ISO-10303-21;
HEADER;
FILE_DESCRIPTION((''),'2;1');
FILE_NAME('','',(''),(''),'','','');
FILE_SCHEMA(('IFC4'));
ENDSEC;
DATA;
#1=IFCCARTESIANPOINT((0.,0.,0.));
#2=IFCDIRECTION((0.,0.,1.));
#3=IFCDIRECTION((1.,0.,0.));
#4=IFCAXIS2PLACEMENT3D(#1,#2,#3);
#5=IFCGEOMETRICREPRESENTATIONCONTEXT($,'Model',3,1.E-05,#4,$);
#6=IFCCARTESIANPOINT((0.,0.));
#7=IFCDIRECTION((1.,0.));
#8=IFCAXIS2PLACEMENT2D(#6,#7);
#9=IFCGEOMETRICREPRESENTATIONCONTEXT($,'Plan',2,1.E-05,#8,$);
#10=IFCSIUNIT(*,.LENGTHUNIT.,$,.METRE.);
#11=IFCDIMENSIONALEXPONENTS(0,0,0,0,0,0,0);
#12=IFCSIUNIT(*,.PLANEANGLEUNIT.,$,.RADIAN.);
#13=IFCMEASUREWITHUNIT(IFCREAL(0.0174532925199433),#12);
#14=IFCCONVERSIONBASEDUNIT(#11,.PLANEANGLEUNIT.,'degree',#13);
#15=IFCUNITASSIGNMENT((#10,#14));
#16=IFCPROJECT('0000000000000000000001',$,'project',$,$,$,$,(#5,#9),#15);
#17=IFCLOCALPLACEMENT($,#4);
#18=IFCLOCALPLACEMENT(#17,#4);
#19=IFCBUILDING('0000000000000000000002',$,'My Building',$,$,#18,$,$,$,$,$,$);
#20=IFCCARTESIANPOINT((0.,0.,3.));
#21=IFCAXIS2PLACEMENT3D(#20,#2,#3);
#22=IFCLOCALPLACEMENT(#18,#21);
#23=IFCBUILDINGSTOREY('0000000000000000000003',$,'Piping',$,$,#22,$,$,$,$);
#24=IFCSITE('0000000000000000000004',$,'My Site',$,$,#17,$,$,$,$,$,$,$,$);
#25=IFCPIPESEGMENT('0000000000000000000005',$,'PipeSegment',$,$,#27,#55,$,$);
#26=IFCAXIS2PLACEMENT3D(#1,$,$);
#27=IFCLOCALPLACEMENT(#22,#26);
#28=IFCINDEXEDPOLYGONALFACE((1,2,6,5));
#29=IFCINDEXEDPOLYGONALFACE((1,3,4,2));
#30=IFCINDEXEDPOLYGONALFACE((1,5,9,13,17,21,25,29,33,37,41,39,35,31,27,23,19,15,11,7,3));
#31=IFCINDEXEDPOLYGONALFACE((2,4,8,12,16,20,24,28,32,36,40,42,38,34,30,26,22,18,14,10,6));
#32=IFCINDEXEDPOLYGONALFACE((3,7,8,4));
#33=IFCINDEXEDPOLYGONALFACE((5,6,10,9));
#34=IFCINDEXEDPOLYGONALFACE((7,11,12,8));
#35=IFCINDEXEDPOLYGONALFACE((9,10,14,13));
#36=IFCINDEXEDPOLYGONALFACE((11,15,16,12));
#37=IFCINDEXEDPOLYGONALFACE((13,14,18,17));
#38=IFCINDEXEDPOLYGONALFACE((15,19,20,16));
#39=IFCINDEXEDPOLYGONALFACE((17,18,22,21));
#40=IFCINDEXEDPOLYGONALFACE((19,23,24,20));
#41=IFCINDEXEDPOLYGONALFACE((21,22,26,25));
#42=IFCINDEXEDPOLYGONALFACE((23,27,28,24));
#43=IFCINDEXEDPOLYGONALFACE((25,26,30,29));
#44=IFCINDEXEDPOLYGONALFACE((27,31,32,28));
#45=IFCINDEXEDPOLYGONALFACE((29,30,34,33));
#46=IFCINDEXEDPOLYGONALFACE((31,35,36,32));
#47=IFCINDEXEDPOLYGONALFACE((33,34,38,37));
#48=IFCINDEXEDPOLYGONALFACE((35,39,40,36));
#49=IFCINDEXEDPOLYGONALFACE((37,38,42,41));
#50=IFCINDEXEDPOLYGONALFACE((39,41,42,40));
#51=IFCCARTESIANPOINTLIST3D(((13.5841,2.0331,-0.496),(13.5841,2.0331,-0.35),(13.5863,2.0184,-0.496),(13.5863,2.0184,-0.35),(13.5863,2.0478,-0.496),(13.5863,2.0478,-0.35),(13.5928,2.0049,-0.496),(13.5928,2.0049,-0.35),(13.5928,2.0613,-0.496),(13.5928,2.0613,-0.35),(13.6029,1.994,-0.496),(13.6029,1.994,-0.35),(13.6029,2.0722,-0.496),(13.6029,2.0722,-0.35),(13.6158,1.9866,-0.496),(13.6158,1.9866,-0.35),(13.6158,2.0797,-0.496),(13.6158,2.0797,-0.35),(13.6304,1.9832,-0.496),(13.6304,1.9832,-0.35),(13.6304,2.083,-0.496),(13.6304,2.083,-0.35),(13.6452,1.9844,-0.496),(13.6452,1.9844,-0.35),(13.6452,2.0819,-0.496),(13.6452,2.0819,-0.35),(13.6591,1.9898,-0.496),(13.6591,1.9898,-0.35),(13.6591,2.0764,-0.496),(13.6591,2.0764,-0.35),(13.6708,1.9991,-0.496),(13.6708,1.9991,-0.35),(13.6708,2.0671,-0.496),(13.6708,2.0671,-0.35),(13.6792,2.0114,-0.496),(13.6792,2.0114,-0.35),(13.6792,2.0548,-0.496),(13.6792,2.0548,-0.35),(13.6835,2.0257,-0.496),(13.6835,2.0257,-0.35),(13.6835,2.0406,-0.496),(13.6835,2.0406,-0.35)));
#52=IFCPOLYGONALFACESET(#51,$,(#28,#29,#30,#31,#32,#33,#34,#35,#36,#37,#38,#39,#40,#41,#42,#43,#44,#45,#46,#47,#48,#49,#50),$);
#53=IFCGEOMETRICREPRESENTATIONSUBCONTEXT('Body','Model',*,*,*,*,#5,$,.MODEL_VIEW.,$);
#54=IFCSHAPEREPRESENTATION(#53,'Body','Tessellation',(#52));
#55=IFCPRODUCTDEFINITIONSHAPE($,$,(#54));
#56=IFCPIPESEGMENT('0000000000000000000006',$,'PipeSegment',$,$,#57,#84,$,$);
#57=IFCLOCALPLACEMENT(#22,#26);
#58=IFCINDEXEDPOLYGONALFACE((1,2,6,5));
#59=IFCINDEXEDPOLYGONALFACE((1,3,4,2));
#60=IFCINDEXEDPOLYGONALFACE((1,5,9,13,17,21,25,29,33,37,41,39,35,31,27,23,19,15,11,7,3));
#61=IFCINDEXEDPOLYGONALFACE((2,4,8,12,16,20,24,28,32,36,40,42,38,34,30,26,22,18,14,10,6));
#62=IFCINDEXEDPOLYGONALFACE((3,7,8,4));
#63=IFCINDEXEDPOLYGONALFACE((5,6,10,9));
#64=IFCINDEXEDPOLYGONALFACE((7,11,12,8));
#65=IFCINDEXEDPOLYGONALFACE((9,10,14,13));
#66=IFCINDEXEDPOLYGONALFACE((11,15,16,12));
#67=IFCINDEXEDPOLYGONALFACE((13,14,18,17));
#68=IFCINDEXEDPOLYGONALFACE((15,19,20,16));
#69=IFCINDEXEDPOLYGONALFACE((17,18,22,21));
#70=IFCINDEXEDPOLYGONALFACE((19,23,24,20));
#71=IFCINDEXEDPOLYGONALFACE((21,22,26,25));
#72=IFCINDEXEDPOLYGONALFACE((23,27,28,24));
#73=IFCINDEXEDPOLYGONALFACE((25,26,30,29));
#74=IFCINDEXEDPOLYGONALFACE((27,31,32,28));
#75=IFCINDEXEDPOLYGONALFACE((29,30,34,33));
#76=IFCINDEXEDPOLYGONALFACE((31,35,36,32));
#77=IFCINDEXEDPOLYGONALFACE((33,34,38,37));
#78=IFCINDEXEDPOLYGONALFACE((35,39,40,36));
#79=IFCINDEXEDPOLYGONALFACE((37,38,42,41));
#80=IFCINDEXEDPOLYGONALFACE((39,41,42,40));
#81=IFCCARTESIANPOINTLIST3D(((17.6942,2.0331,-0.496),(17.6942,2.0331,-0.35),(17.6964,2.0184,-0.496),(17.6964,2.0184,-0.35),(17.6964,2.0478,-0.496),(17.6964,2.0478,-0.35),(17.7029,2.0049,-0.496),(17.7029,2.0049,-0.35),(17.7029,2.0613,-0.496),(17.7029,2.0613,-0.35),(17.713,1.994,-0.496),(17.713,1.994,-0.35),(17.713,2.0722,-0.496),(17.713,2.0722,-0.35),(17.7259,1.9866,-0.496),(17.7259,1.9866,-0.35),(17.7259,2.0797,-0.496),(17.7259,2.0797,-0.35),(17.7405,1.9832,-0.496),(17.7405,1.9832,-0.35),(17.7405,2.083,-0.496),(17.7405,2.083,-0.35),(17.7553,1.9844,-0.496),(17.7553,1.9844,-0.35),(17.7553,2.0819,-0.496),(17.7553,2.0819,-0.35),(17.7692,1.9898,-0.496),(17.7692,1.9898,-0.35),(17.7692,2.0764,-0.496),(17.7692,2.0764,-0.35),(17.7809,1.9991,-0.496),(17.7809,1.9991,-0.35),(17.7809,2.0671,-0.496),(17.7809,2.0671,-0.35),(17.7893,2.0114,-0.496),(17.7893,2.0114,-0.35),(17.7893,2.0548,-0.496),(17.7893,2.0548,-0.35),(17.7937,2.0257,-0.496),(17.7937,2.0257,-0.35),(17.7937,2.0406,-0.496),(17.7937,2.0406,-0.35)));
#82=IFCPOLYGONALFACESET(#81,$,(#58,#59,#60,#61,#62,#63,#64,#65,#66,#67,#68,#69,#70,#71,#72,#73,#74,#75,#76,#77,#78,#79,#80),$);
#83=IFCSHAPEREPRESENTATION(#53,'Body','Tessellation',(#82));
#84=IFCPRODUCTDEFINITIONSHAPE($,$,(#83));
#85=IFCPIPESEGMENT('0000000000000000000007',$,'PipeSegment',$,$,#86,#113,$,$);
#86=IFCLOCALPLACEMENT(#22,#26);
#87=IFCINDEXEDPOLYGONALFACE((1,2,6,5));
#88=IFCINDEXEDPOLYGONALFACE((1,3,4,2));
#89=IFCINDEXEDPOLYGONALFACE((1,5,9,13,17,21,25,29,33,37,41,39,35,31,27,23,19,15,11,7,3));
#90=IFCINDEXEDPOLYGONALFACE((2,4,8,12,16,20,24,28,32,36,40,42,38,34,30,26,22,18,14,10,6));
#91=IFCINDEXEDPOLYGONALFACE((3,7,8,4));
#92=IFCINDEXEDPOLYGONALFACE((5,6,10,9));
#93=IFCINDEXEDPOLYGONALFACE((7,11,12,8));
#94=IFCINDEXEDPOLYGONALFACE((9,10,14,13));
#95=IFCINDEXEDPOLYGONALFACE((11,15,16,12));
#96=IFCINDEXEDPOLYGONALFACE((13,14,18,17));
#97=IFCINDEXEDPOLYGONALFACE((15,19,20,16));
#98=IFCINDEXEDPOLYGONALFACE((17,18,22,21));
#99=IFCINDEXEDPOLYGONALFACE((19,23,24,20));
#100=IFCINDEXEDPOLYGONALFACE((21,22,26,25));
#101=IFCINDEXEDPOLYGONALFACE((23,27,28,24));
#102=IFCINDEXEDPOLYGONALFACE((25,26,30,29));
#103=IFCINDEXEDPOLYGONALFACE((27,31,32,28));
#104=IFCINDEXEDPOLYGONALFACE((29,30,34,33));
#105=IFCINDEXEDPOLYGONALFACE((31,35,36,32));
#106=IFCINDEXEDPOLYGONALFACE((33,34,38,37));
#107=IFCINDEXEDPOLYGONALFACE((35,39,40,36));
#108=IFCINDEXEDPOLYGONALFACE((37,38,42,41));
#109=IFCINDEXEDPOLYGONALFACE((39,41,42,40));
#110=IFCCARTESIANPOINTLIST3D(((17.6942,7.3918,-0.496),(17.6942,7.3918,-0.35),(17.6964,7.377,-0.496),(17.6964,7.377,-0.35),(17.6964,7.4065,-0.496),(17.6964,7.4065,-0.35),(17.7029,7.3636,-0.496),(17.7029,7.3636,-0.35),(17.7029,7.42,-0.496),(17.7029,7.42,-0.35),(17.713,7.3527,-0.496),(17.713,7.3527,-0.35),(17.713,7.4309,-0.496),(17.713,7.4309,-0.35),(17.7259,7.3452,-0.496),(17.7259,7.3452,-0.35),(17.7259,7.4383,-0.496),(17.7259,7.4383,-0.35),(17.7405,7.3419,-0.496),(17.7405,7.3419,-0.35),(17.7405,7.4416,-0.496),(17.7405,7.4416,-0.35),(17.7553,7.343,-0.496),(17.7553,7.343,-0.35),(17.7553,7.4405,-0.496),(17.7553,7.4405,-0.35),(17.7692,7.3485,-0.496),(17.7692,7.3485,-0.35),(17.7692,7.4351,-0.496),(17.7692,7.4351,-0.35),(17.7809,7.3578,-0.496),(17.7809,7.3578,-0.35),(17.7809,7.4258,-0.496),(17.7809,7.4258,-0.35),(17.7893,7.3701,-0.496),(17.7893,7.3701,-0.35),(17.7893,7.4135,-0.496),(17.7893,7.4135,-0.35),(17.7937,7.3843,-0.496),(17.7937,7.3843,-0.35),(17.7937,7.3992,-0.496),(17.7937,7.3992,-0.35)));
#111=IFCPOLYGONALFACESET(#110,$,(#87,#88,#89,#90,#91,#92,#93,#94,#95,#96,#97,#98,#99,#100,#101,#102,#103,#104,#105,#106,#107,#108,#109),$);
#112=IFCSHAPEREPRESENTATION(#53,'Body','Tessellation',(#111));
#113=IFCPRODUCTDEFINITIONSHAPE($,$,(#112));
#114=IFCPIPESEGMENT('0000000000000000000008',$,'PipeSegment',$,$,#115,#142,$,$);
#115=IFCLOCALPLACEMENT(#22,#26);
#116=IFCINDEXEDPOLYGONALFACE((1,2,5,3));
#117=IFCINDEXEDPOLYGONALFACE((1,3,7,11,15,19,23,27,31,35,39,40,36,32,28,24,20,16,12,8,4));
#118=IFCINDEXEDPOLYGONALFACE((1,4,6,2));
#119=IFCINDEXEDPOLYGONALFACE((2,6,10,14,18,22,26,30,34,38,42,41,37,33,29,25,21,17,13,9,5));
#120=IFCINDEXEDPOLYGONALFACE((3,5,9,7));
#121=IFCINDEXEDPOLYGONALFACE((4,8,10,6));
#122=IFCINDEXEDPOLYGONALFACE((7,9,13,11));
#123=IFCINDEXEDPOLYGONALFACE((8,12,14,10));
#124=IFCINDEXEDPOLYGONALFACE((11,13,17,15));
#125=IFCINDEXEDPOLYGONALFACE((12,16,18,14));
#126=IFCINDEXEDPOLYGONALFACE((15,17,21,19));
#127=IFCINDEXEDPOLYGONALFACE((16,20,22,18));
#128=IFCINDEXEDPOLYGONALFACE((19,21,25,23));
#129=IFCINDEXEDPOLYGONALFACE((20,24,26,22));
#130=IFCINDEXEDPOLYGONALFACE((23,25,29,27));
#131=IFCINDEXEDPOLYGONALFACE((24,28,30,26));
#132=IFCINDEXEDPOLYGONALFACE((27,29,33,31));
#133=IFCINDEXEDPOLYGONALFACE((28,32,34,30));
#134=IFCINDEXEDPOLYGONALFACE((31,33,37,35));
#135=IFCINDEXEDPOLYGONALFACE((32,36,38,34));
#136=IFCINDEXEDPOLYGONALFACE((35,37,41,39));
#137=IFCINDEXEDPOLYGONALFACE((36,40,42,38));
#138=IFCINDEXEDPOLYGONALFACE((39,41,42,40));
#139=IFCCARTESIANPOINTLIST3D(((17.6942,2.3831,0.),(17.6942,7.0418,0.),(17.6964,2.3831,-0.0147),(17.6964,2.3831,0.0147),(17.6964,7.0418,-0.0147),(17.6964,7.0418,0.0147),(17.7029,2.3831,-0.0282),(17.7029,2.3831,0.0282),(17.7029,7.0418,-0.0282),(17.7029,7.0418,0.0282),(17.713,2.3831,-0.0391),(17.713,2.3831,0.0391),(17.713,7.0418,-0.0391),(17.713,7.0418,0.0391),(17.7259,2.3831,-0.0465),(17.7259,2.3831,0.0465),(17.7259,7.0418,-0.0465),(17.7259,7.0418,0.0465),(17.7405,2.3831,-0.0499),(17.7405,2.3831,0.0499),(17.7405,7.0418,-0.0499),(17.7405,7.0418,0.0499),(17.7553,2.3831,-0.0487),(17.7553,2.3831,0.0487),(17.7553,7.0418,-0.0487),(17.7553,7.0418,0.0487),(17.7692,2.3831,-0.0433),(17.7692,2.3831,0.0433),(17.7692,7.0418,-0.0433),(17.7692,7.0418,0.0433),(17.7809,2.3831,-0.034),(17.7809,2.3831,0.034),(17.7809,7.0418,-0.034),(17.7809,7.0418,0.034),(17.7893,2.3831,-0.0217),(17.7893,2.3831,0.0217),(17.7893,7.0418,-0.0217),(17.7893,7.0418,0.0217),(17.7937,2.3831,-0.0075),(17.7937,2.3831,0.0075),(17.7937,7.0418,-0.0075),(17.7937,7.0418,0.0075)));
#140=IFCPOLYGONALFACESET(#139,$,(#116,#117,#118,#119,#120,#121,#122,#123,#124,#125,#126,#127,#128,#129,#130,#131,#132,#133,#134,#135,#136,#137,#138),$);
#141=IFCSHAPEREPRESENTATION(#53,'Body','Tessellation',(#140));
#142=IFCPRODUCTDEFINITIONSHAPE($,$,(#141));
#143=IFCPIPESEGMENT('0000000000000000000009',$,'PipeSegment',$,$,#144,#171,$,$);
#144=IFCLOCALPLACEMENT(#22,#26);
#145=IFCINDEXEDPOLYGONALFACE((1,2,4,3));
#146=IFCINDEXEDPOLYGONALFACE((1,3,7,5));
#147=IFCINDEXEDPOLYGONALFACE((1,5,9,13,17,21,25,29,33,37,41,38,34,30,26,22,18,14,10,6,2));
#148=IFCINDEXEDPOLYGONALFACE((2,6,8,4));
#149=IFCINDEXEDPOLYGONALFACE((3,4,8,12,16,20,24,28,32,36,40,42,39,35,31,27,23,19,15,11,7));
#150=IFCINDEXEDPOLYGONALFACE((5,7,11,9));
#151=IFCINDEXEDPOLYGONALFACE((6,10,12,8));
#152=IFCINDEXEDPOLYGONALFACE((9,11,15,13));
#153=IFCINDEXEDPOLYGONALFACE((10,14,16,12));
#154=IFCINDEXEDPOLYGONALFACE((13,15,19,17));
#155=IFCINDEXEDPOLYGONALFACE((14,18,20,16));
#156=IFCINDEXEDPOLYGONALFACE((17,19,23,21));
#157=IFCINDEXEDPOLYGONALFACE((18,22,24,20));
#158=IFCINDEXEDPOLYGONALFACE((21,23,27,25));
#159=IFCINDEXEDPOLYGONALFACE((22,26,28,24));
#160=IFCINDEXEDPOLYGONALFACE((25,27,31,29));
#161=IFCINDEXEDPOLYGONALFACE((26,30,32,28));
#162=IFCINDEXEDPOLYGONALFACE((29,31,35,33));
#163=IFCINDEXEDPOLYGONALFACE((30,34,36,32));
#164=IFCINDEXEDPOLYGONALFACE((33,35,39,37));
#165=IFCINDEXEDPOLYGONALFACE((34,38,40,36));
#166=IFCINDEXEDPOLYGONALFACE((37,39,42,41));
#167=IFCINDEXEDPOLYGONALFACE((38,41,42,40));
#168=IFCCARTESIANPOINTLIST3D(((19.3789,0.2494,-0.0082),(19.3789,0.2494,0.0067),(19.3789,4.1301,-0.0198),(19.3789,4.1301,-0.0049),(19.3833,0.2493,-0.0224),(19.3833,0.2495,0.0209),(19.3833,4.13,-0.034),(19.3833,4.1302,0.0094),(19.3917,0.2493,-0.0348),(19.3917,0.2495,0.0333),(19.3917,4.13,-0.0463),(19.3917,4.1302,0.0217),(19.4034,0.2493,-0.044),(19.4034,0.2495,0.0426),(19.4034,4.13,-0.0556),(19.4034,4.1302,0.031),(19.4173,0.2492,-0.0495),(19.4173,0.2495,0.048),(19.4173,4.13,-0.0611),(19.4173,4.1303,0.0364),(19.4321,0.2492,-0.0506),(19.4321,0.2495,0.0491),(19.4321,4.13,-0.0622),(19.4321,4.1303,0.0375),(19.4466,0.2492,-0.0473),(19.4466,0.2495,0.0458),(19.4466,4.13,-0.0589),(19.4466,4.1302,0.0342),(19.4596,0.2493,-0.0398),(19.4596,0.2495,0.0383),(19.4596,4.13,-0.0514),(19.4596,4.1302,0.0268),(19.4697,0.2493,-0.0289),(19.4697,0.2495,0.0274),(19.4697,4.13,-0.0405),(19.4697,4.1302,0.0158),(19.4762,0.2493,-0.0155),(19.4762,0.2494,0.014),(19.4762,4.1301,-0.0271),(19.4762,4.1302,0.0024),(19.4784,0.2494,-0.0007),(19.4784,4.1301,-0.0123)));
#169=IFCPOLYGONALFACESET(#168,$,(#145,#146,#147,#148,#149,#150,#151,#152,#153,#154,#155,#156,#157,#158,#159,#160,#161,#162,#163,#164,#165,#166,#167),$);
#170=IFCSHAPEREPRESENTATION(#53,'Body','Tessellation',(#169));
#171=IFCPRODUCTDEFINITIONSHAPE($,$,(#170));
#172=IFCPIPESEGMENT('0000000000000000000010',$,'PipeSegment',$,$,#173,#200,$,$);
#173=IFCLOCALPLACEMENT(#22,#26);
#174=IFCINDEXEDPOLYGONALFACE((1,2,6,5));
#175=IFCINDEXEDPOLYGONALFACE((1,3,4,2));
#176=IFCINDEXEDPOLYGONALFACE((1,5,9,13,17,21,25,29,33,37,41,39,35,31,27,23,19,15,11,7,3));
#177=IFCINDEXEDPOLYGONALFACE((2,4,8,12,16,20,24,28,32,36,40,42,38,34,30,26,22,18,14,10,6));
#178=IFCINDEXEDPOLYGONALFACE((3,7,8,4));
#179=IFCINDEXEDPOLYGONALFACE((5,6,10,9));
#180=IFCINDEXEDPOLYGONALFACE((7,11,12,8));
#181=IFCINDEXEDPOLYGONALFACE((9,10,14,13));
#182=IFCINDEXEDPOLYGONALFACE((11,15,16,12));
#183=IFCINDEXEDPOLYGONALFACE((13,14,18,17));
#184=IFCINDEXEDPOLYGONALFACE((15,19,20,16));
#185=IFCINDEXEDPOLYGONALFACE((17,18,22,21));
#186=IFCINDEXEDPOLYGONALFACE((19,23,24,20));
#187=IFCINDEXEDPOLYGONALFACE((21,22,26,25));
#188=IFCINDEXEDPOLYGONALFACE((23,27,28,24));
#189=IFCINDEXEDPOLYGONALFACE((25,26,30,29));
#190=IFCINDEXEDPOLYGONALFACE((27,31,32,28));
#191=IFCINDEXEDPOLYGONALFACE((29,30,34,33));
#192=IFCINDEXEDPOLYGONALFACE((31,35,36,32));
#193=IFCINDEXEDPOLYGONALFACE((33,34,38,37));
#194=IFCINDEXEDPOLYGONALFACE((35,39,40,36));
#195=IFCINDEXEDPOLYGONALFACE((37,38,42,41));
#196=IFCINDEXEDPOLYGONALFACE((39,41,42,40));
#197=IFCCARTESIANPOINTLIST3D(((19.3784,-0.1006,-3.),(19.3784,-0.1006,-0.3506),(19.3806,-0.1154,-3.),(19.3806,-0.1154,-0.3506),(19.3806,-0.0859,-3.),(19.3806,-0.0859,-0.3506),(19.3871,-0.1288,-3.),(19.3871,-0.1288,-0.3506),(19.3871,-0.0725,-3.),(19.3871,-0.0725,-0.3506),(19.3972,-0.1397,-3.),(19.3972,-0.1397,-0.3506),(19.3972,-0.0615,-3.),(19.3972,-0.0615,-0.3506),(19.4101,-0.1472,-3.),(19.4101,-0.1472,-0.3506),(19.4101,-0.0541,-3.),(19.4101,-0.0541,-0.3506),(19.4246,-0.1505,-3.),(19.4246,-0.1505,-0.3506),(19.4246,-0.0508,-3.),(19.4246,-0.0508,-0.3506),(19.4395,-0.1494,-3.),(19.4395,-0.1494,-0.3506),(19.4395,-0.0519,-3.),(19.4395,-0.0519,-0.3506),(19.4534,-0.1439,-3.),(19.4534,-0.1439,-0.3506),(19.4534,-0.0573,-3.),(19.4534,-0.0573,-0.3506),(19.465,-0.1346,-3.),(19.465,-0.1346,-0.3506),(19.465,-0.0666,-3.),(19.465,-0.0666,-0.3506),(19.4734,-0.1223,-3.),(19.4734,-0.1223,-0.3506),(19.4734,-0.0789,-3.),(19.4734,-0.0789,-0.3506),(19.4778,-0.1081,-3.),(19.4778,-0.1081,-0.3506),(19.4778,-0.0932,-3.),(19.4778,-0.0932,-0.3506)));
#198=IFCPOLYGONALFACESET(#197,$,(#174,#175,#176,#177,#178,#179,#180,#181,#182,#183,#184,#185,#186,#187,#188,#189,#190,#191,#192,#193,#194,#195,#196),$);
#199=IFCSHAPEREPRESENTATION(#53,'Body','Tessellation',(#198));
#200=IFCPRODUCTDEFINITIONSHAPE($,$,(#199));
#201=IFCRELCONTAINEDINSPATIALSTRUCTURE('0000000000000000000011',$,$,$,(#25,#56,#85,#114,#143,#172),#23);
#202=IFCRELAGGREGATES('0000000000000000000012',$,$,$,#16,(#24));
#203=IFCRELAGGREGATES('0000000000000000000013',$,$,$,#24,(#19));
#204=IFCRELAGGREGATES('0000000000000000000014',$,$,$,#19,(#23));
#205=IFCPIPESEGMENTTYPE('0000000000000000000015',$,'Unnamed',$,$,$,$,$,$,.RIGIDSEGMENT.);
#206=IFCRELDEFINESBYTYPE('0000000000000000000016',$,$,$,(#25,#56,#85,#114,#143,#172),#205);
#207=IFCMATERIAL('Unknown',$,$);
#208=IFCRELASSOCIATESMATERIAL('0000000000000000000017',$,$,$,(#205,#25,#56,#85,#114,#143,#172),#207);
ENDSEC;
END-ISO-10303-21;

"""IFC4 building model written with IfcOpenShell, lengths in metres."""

from ifc_helpers import new_model, entity, si_unit, converted_unit, frame, origin_with_axes, origin_2d_with_axis, place, context, subcontext, project, spatial, circle, extrude, material, material_profile, profile_set, profile_usage, type_object, element, save


model = new_model("IFC4")

# Units and contexts
model_context = context("Model", 3, precision=1e-05, world=origin_with_axes())
plan_context = context("Plan", 2, precision=1e-05, world=origin_2d_with_axis())
body_context = subcontext(model_context, "Body", "Model", "MODEL_VIEW")
ifc_project = project(units=[si_unit("LENGTHUNIT", "METRE"), converted_unit("PLANEANGLEUNIT", "degree", entity("IfcReal", 0.0174532925199433), si_unit("PLANEANGLEUNIT", "RADIAN"), dimensions=[0, 0, 0, 0, 0, 0, 0])], contexts=[model_context, plan_context])

# Site, building, storey
site_placement = place(None, origin_with_axes())
site = spatial("IfcSite", under=ifc_project, at=site_placement, Name="My Site")
building_placement = place(site_placement, origin_with_axes())
building = spatial("IfcBuilding", under=site, at=building_placement, Name="My Building")
storey_placement = place(building_placement, frame((0.0, 0.0, 3.0), z_axis=(0.0, 0.0, 1.0), x_axis=(1.0, 0.0, 0.0)))
storey = spatial("IfcBuildingStorey", under=building, at=storey_placement, Name="Piping")

# Pipe segments
ifc_material = material(Name="Unknown")
ifc_material_profile = material_profile(ifc_material, circle(Radius=0.05))
ifc_profile_set = profile_set([ifc_material_profile])
pipe_segment_type = type_object("IfcPipeSegmentType", Name="Unnamed", PredefinedType="RIGIDSEGMENT", material=ifc_profile_set)
ifc_profile_usage_1 = profile_usage(ifc_profile_set, cardinal=5)
pipe_segment_1_placement = place(storey_placement, frame((13.6341, 2.0331, -0.35), z_axis=(0.0, 0.0, -1.0), x_axis=(-1.0, 0.0, 0.0)))
element("IfcPipeSegment", 1, at=pipe_segment_1_placement, inside=storey, type_object=pipe_segment_type, material=ifc_profile_usage_1, Name="PipeSegment", context=body_context, shape_type="SweptSolid", body=[
    extrude(circle(Radius=0.05), origin_with_axes(), (0.0, 0.0, 1.0), 0.1459),
])
ifc_profile_usage_2 = profile_usage(ifc_profile_set, cardinal=5)
pipe_segment_2_placement = place(storey_placement, frame((17.7442, 2.0331, -0.35), z_axis=(0.0, 0.0, -1.0), x_axis=(-1.0, 0.0, 0.0)))
element("IfcPipeSegment", 2, at=pipe_segment_2_placement, inside=storey, type_object=pipe_segment_type, material=ifc_profile_usage_2, Name="PipeSegment", context=body_context, shape_type="SweptSolid", body=[
    extrude(circle(Radius=0.05), origin_with_axes(), (0.0, 0.0, 1.0), 0.1459),
])
ifc_profile_usage_3 = profile_usage(ifc_profile_set, cardinal=5)
pipe_segment_3_placement = place(storey_placement, frame((17.7442, 7.3918, -0.35), z_axis=(0.0, 0.0, -1.0), x_axis=(-1.0, 0.0, 0.0)))
element("IfcPipeSegment", 3, at=pipe_segment_3_placement, inside=storey, type_object=pipe_segment_type, material=ifc_profile_usage_3, Name="PipeSegment", context=body_context, shape_type="SweptSolid", body=[
    extrude(circle(Radius=0.05), origin_with_axes(), (0.0, 0.0, 1.0), 0.1459),
])
ifc_profile_usage_4 = profile_usage(ifc_profile_set, cardinal=5)
pipe_segment_4_placement = place(storey_placement, frame((17.7442, 2.3831, 0.0), z_axis=(0.0, 1.0, 0.0), x_axis=(-1.0, 0.0, 0.0)))
element("IfcPipeSegment", 4, at=pipe_segment_4_placement, inside=storey, type_object=pipe_segment_type, material=ifc_profile_usage_4, Name="PipeSegment", context=body_context, shape_type="SweptSolid", body=[
    extrude(circle(Radius=0.05), origin_with_axes(), (0.0, 0.0, 1.0), 4.6587),
])
ifc_profile_usage_5 = profile_usage(ifc_profile_set, cardinal=5)
pipe_segment_5_placement = place(storey_placement, frame((19.4284, 4.1301, -0.0123), z_axis=(0.0, -0.999996, 0.002986), x_axis=(1.0, 0.0, 0.0)))
element("IfcPipeSegment", 5, at=pipe_segment_5_placement, inside=storey, type_object=pipe_segment_type, material=ifc_profile_usage_5, Name="PipeSegment", context=body_context, shape_type="SweptSolid", body=[
    extrude(circle(Radius=0.05), origin_with_axes(), (0.0, 0.0, 1.0), 3.8807),
])
ifc_profile_usage_6 = profile_usage(ifc_profile_set, cardinal=5)
pipe_segment_6_placement = place(storey_placement, frame((19.4284, -0.1006, -0.3506), z_axis=(0.0, 0.0, -1.0), x_axis=(-1.0, 0.0, 0.0)))
element("IfcPipeSegment", 6, at=pipe_segment_6_placement, inside=storey, type_object=pipe_segment_type, material=ifc_profile_usage_6, Name="PipeSegment", context=body_context, shape_type="SweptSolid", body=[
    extrude(circle(Radius=0.05), origin_with_axes(), (0.0, 0.0, 1.0), 2.6494),
])

save(model, "model.ifc")
